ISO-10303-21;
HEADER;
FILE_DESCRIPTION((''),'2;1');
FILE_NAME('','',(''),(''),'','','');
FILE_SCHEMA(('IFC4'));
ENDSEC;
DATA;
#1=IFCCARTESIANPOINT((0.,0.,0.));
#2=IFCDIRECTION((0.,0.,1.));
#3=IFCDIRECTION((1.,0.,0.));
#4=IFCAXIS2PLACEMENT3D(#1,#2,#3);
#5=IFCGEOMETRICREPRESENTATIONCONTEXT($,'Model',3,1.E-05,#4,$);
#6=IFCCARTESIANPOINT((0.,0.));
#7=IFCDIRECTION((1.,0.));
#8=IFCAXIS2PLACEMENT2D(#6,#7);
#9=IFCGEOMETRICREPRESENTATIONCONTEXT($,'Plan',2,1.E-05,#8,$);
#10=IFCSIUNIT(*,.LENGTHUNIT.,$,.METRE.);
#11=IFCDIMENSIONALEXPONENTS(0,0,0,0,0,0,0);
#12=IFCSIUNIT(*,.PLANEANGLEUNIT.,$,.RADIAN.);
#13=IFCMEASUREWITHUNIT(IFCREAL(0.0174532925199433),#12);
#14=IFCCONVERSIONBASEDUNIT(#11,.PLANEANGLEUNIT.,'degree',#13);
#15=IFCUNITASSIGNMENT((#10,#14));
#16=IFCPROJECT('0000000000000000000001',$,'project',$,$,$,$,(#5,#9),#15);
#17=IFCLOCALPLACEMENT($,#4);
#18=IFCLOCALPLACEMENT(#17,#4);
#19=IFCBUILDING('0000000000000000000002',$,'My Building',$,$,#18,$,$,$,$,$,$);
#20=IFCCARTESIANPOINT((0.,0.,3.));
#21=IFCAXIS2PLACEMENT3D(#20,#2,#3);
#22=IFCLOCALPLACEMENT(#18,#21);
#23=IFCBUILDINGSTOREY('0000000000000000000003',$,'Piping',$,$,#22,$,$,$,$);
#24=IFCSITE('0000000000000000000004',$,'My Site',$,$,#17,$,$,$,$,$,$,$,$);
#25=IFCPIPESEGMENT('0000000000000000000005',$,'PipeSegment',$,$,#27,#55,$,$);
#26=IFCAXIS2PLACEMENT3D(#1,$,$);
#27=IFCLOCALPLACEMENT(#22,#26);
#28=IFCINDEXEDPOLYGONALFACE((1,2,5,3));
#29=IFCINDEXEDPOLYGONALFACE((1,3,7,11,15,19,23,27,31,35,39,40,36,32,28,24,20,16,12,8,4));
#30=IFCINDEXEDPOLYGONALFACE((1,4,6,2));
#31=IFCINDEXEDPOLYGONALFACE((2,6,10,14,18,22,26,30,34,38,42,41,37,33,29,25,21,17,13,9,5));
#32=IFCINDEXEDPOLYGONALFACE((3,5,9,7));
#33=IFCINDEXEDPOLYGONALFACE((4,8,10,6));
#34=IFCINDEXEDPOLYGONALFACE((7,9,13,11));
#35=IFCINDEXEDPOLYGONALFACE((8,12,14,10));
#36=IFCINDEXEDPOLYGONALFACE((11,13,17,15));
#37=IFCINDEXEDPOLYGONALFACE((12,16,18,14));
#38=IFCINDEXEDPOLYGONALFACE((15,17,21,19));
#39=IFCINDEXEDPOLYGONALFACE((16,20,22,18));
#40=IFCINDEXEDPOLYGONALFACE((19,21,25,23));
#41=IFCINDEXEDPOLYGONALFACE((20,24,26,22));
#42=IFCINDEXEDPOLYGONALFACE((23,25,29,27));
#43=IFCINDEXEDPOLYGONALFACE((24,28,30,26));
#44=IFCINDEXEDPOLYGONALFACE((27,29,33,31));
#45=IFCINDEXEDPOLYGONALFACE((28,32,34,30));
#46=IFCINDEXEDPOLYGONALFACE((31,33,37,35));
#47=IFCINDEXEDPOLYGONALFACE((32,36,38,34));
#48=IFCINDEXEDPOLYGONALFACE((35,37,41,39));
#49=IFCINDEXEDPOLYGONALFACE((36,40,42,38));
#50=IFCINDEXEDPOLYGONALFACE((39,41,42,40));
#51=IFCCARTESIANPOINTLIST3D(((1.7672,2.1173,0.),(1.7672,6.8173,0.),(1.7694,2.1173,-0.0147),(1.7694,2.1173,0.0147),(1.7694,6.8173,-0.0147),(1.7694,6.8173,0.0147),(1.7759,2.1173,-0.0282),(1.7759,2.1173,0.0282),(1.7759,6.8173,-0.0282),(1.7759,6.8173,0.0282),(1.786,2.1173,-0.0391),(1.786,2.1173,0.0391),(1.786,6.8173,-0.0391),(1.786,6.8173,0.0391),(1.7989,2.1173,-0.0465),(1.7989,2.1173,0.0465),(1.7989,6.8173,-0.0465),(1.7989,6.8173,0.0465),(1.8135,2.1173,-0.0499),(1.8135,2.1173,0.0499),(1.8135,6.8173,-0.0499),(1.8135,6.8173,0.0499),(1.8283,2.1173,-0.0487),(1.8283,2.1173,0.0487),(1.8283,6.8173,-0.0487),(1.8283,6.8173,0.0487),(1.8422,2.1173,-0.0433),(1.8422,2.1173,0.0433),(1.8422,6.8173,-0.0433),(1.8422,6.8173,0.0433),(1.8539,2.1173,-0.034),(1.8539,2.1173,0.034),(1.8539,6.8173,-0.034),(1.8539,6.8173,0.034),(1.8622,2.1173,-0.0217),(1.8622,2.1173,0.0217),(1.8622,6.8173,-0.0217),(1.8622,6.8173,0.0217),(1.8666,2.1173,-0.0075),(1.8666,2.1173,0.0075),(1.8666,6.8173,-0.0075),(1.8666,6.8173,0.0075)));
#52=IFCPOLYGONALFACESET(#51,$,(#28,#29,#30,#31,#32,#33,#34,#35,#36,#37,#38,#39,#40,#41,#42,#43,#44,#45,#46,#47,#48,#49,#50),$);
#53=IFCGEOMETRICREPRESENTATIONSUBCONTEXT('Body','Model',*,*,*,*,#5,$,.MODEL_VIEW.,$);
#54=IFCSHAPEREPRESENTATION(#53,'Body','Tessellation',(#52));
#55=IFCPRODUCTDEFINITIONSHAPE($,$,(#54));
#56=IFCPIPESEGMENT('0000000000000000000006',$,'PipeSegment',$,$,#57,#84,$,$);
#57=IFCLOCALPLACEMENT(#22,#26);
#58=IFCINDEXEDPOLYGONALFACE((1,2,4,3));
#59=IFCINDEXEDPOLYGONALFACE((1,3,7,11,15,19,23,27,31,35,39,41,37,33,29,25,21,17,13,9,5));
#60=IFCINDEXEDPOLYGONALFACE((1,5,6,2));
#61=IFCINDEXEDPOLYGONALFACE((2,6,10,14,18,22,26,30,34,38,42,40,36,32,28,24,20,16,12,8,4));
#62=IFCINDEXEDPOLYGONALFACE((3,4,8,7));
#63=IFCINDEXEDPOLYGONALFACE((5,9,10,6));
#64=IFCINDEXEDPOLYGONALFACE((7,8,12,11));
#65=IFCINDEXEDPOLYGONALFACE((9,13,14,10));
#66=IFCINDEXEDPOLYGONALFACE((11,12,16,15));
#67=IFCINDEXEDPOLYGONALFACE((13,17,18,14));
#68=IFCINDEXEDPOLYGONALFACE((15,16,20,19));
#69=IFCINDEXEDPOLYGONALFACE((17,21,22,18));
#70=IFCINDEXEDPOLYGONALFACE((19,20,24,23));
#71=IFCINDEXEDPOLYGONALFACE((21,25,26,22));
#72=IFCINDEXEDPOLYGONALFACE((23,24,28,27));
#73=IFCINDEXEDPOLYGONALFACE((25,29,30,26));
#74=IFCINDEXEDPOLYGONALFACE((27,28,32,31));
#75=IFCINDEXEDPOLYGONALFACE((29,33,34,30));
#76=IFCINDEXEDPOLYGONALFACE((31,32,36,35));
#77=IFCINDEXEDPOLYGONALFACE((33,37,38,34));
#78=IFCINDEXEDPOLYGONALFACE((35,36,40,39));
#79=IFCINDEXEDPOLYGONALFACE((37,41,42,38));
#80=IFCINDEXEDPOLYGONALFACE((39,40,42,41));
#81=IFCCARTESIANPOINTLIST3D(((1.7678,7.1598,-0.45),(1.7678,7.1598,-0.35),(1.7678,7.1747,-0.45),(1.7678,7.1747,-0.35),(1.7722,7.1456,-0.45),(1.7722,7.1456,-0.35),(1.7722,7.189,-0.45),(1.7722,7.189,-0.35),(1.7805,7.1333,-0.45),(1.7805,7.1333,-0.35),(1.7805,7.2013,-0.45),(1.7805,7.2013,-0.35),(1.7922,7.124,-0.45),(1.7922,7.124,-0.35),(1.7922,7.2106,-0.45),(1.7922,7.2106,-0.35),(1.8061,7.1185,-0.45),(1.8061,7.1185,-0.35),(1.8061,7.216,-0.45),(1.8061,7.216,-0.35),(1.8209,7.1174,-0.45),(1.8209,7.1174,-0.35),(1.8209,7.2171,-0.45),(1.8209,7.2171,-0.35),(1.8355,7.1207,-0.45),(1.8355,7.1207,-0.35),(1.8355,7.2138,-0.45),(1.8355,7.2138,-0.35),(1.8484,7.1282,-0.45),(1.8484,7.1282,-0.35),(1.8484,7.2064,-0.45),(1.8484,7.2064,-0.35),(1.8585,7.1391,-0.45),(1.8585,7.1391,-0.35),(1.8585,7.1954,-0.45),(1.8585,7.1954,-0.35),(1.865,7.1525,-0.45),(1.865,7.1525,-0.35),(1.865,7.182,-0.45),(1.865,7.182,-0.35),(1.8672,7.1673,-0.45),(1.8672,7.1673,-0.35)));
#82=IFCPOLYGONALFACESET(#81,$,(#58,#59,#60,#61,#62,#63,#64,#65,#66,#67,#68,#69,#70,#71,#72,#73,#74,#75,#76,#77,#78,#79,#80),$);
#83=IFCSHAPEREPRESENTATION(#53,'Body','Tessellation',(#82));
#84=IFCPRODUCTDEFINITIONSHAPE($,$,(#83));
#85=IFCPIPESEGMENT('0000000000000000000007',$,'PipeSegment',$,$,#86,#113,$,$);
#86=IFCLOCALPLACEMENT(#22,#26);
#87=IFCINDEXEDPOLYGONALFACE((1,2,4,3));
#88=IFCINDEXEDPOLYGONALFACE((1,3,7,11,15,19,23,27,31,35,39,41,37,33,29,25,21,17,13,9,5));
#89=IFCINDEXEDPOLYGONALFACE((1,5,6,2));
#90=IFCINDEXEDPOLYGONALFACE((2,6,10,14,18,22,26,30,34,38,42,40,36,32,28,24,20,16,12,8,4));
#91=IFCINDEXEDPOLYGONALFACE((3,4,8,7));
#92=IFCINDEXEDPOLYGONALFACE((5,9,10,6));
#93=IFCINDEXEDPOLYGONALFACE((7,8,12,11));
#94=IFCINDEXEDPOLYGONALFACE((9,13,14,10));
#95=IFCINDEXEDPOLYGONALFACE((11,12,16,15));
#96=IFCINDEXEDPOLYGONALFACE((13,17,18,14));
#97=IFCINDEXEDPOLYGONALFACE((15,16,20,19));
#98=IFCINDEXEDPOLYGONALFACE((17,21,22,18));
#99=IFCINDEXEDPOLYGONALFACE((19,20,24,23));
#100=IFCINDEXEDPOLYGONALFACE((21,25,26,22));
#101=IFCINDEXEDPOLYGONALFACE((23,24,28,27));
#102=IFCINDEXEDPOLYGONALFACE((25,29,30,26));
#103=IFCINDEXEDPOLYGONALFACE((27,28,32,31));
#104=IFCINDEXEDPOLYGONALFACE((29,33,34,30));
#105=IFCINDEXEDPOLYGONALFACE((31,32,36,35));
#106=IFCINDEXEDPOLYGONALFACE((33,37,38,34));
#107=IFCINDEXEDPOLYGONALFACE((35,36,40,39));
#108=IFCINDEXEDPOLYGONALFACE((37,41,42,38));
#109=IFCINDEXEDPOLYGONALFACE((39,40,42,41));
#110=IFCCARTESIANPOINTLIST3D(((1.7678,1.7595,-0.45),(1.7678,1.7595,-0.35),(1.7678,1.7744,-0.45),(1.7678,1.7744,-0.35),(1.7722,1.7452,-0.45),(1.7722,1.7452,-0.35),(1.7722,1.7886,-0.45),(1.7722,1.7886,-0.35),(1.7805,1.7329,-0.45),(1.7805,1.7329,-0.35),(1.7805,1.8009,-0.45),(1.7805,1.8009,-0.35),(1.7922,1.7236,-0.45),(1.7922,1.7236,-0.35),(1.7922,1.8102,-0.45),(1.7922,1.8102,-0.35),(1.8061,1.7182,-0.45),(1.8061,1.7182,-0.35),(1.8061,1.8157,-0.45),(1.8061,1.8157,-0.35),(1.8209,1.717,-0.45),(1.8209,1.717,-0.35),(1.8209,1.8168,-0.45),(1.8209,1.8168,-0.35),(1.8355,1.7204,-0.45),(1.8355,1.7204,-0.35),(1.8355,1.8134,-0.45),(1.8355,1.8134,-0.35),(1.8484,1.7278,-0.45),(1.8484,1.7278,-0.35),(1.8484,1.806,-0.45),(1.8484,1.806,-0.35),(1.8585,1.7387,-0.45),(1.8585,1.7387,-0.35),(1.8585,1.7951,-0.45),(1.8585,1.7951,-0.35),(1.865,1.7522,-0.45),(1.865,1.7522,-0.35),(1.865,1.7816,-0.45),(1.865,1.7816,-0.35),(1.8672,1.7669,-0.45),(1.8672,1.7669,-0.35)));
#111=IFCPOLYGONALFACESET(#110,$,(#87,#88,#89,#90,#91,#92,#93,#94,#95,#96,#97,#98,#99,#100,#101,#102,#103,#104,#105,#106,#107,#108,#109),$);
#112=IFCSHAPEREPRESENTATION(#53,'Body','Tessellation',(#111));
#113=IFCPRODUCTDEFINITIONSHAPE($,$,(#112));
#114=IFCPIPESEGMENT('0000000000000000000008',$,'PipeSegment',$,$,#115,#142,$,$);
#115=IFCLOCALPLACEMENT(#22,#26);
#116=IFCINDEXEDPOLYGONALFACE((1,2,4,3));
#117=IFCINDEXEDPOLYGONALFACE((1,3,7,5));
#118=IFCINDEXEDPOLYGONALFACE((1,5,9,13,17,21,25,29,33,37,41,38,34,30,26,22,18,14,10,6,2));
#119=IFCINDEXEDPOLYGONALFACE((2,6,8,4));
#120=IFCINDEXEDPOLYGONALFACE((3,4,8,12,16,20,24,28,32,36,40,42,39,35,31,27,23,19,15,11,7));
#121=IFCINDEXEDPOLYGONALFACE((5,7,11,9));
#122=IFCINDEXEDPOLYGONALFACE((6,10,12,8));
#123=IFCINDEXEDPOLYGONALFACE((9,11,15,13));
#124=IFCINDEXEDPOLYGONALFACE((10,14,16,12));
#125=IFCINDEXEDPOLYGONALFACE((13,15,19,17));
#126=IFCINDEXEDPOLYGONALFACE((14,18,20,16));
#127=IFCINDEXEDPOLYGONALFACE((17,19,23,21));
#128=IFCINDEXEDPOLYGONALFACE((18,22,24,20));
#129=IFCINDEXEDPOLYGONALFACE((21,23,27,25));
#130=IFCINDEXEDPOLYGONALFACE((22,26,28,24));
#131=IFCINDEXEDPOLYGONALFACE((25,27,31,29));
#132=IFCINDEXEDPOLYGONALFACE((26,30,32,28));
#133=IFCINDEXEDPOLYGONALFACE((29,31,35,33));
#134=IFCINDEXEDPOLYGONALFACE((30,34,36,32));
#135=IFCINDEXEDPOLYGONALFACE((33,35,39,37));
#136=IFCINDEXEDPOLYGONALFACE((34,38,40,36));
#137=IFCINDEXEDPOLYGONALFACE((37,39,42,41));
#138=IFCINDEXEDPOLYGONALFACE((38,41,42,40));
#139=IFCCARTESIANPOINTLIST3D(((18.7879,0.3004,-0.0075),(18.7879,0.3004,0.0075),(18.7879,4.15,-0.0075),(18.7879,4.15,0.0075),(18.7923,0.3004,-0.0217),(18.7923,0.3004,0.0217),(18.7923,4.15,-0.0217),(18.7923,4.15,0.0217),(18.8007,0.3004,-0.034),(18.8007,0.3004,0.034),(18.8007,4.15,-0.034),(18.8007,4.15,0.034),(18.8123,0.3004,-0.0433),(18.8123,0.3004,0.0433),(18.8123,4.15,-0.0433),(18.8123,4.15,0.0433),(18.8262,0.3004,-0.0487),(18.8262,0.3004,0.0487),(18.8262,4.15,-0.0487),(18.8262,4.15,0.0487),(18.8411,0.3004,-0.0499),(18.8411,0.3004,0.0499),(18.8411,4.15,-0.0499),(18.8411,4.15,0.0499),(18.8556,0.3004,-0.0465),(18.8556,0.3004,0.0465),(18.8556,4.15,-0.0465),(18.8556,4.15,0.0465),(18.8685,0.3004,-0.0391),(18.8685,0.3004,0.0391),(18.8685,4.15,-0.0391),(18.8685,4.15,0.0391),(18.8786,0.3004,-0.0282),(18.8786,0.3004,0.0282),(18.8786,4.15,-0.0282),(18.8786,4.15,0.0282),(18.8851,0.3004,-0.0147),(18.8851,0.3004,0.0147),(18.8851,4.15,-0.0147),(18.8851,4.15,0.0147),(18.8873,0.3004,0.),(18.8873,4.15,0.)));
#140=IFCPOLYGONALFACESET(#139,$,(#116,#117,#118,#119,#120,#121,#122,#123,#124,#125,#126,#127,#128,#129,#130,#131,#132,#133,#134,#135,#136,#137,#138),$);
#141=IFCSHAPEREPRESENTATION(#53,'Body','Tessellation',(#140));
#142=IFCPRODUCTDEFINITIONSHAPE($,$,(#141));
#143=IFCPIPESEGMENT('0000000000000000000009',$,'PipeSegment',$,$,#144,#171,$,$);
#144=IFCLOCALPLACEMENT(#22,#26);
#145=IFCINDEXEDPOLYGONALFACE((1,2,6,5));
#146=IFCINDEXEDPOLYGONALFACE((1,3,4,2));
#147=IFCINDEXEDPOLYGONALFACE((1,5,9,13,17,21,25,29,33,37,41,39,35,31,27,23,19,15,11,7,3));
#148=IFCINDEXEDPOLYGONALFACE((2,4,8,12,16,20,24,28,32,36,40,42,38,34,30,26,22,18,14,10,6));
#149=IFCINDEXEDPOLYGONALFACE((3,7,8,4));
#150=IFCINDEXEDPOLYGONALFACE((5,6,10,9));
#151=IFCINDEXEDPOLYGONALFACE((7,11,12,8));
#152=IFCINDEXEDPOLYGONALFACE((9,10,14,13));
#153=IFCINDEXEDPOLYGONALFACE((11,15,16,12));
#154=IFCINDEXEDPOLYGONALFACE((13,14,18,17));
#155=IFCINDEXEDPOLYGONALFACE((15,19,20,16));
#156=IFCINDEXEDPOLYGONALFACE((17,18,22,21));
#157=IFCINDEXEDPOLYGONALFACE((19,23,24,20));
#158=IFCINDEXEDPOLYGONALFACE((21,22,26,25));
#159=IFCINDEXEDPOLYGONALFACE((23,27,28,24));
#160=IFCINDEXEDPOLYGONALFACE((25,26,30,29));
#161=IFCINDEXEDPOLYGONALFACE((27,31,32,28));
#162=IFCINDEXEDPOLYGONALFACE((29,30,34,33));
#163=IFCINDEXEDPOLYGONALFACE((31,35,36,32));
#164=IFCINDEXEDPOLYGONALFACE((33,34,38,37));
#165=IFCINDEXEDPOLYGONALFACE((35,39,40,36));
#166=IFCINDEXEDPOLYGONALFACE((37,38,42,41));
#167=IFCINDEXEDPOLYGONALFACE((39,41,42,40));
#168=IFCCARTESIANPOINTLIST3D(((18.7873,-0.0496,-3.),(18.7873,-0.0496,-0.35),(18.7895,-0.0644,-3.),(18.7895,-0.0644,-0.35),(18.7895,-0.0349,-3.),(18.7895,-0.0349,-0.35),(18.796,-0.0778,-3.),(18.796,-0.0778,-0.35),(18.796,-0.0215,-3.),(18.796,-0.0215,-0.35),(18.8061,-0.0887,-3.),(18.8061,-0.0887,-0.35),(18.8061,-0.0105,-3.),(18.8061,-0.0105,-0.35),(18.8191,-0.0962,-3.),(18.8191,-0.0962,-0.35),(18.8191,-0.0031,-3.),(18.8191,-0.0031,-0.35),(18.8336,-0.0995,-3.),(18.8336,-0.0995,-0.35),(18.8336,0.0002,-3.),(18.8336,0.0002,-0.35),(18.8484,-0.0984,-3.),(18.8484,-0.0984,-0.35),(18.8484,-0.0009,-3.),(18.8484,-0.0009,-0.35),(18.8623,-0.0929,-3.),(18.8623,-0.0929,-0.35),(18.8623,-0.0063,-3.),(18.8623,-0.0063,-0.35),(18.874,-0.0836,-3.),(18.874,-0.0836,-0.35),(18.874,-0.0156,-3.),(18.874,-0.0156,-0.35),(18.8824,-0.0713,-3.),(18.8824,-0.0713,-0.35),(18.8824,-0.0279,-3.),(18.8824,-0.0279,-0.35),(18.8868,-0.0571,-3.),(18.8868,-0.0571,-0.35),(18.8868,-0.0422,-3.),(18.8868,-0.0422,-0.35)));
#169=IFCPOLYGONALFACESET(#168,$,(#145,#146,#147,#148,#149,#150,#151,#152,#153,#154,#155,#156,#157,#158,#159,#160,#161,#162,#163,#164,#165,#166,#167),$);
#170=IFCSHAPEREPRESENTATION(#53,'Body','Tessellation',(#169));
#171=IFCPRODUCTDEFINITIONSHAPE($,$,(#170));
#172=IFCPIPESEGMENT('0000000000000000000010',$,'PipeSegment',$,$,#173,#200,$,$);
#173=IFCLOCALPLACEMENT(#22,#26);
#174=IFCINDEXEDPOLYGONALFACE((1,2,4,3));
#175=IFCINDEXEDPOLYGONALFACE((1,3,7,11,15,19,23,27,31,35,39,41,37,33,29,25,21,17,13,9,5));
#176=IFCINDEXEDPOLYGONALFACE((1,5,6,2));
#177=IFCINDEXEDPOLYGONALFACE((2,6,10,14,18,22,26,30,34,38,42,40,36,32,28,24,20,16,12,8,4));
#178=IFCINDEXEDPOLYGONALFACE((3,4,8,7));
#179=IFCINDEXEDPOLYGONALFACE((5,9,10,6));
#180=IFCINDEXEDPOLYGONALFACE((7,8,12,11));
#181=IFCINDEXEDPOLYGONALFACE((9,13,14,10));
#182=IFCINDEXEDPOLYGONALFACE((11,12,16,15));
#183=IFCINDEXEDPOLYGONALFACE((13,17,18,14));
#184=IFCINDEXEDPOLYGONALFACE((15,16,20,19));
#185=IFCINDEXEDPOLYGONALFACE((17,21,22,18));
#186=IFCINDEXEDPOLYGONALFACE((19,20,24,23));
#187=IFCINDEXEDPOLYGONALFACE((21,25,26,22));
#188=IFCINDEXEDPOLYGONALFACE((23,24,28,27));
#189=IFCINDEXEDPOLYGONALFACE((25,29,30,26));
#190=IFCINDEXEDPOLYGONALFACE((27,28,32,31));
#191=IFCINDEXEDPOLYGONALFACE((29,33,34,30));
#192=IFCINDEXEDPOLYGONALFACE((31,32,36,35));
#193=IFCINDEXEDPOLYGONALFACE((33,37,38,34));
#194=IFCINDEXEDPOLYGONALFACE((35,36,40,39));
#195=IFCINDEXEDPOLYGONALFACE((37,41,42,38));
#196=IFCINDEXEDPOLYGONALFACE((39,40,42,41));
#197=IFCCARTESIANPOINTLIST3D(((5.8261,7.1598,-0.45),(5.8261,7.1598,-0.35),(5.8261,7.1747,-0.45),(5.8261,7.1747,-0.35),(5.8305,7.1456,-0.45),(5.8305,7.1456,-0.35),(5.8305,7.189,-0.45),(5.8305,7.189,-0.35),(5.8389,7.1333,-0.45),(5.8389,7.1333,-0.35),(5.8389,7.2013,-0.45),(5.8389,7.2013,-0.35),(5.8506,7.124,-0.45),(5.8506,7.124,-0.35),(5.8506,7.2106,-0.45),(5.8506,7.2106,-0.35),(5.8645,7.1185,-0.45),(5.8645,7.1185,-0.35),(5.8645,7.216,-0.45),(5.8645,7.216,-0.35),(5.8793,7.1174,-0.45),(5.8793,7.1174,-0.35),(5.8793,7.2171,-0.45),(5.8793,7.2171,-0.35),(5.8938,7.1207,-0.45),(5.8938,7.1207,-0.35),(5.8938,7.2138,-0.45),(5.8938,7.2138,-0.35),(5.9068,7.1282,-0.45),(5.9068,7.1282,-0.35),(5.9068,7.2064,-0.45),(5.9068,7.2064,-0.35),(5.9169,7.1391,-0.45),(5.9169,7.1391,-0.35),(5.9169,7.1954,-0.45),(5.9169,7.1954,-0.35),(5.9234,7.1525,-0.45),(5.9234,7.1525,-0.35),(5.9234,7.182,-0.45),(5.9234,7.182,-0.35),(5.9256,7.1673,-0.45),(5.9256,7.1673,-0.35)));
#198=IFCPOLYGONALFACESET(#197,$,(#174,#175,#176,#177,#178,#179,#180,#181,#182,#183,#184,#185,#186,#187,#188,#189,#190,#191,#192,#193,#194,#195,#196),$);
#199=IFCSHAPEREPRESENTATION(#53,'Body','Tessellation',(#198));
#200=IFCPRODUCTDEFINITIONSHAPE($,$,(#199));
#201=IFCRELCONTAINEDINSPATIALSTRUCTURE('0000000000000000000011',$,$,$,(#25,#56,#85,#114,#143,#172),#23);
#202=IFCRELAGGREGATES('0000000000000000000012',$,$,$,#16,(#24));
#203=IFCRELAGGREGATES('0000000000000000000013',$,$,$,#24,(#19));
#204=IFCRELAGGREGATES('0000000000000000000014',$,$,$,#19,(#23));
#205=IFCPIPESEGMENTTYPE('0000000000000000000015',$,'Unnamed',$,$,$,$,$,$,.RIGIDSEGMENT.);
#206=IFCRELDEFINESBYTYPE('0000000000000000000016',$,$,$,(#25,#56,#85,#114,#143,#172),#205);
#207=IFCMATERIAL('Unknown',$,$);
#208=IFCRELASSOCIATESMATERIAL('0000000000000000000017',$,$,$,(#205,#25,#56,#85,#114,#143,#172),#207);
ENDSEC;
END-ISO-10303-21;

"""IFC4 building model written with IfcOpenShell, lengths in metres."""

from ifc_helpers import new_model, entity, si_unit, converted_unit, frame, origin_with_axes, origin_2d_with_axis, place, context, subcontext, project, spatial, circle, extrude, material, material_profile, profile_set, profile_usage, type_object, element, save


model = new_model("IFC4")

# Units and contexts
model_context = context("Model", 3, precision=1e-05, world=origin_with_axes())
plan_context = context("Plan", 2, precision=1e-05, world=origin_2d_with_axis())
body_context = subcontext(model_context, "Body", "Model", "MODEL_VIEW")
ifc_project = project(units=[si_unit("LENGTHUNIT", "METRE"), converted_unit("PLANEANGLEUNIT", "degree", entity("IfcReal", 0.0174532925199433), si_unit("PLANEANGLEUNIT", "RADIAN"), dimensions=[0, 0, 0, 0, 0, 0, 0])], contexts=[model_context, plan_context])

# Site, building, storey
site_placement = place(None, origin_with_axes())
site = spatial("IfcSite", under=ifc_project, at=site_placement, Name="My Site")
building_placement = place(site_placement, origin_with_axes())
building = spatial("IfcBuilding", under=site, at=building_placement, Name="My Building")
storey_placement = place(building_placement, frame((0.0, 0.0, 3.0), z_axis=(0.0, 0.0, 1.0), x_axis=(1.0, 0.0, 0.0)))
storey = spatial("IfcBuildingStorey", under=building, at=storey_placement, Name="Piping")

# Pipe segments
ifc_material = material(Name="Unknown")
ifc_material_profile = material_profile(ifc_material, circle(Radius=0.05))
ifc_profile_set = profile_set([ifc_material_profile])
ifc_profile_usage_1 = profile_usage(ifc_profile_set, cardinal=5)
pipe_segment_type = type_object("IfcPipeSegmentType", Name="Unnamed", PredefinedType="RIGIDSEGMENT", material=ifc_profile_set)
pipe_segment_1_placement = place(storey_placement, frame((1.8172, 2.1173, 0.0), z_axis=(0.0, 1.0, 0.0), x_axis=(-1.0, 0.0, 0.0)))
element("IfcPipeSegment", 1, at=pipe_segment_1_placement, inside=storey, type_object=pipe_segment_type, material=ifc_profile_usage_1, Name="PipeSegment", context=body_context, shape_type="SweptSolid", body=[
    extrude(circle(Radius=0.05), origin_with_axes(), (0.0, 0.0, 1.0), 4.7),
])
ifc_profile_usage_2 = profile_usage(ifc_profile_set, cardinal=5)
pipe_segment_2_placement = place(storey_placement, frame((1.8172, 7.1673, -0.35), z_axis=(0.0, 0.0, -1.0), x_axis=(1.0, 0.0, 0.0)))
element("IfcPipeSegment", 2, at=pipe_segment_2_placement, inside=storey, type_object=pipe_segment_type, material=ifc_profile_usage_2, Name="PipeSegment", context=body_context, shape_type="SweptSolid", body=[
    extrude(circle(Radius=0.05), origin_with_axes(), (0.0, 0.0, 1.0), 0.1),
])
ifc_profile_usage_3 = profile_usage(ifc_profile_set, cardinal=5)
pipe_segment_3_placement = place(storey_placement, frame((1.8172, 1.7669, -0.35), z_axis=(0.0, 0.0, -1.0), x_axis=(1.0, 0.0, 0.0)))
element("IfcPipeSegment", 3, at=pipe_segment_3_placement, inside=storey, type_object=pipe_segment_type, material=ifc_profile_usage_3, Name="PipeSegment", context=body_context, shape_type="SweptSolid", body=[
    extrude(circle(Radius=0.05), origin_with_axes(), (0.0, 0.0, 1.0), 0.1),
])
ifc_profile_usage_4 = profile_usage(ifc_profile_set, cardinal=5)
pipe_segment_4_placement = place(storey_placement, frame((18.8373, 4.15, 0.0), z_axis=(0.0, -1.0, 0.0), x_axis=(1.0, 0.0, 0.0)))
element("IfcPipeSegment", 4, at=pipe_segment_4_placement, inside=storey, type_object=pipe_segment_type, material=ifc_profile_usage_4, Name="PipeSegment", context=body_context, shape_type="SweptSolid", body=[
    extrude(circle(Radius=0.05), origin_with_axes(), (0.0, 0.0, 1.0), 3.8496),
])
ifc_profile_usage_5 = profile_usage(ifc_profile_set, cardinal=5)
pipe_segment_5_placement = place(storey_placement, frame((18.8373, -0.0496, -0.35), z_axis=(0.0, 0.0, -1.0), x_axis=(-1.0, 0.0, 0.0)))
element("IfcPipeSegment", 5, at=pipe_segment_5_placement, inside=storey, type_object=pipe_segment_type, material=ifc_profile_usage_5, Name="PipeSegment", context=body_context, shape_type="SweptSolid", body=[
    extrude(circle(Radius=0.05), origin_with_axes(), (0.0, 0.0, 1.0), 2.65),
])
ifc_profile_usage_6 = profile_usage(ifc_profile_set, cardinal=5)
pipe_segment_6_placement = place(storey_placement, frame((5.8756, 7.1673, -0.35), z_axis=(0.0, 0.0, -1.0), x_axis=(1.0, 0.0, 0.0)))
element("IfcPipeSegment", 6, at=pipe_segment_6_placement, inside=storey, type_object=pipe_segment_type, material=ifc_profile_usage_6, Name="PipeSegment", context=body_context, shape_type="SweptSolid", body=[
    extrude(circle(Radius=0.05), origin_with_axes(), (0.0, 0.0, 1.0), 0.1),
])

save(model, "model.ifc")
